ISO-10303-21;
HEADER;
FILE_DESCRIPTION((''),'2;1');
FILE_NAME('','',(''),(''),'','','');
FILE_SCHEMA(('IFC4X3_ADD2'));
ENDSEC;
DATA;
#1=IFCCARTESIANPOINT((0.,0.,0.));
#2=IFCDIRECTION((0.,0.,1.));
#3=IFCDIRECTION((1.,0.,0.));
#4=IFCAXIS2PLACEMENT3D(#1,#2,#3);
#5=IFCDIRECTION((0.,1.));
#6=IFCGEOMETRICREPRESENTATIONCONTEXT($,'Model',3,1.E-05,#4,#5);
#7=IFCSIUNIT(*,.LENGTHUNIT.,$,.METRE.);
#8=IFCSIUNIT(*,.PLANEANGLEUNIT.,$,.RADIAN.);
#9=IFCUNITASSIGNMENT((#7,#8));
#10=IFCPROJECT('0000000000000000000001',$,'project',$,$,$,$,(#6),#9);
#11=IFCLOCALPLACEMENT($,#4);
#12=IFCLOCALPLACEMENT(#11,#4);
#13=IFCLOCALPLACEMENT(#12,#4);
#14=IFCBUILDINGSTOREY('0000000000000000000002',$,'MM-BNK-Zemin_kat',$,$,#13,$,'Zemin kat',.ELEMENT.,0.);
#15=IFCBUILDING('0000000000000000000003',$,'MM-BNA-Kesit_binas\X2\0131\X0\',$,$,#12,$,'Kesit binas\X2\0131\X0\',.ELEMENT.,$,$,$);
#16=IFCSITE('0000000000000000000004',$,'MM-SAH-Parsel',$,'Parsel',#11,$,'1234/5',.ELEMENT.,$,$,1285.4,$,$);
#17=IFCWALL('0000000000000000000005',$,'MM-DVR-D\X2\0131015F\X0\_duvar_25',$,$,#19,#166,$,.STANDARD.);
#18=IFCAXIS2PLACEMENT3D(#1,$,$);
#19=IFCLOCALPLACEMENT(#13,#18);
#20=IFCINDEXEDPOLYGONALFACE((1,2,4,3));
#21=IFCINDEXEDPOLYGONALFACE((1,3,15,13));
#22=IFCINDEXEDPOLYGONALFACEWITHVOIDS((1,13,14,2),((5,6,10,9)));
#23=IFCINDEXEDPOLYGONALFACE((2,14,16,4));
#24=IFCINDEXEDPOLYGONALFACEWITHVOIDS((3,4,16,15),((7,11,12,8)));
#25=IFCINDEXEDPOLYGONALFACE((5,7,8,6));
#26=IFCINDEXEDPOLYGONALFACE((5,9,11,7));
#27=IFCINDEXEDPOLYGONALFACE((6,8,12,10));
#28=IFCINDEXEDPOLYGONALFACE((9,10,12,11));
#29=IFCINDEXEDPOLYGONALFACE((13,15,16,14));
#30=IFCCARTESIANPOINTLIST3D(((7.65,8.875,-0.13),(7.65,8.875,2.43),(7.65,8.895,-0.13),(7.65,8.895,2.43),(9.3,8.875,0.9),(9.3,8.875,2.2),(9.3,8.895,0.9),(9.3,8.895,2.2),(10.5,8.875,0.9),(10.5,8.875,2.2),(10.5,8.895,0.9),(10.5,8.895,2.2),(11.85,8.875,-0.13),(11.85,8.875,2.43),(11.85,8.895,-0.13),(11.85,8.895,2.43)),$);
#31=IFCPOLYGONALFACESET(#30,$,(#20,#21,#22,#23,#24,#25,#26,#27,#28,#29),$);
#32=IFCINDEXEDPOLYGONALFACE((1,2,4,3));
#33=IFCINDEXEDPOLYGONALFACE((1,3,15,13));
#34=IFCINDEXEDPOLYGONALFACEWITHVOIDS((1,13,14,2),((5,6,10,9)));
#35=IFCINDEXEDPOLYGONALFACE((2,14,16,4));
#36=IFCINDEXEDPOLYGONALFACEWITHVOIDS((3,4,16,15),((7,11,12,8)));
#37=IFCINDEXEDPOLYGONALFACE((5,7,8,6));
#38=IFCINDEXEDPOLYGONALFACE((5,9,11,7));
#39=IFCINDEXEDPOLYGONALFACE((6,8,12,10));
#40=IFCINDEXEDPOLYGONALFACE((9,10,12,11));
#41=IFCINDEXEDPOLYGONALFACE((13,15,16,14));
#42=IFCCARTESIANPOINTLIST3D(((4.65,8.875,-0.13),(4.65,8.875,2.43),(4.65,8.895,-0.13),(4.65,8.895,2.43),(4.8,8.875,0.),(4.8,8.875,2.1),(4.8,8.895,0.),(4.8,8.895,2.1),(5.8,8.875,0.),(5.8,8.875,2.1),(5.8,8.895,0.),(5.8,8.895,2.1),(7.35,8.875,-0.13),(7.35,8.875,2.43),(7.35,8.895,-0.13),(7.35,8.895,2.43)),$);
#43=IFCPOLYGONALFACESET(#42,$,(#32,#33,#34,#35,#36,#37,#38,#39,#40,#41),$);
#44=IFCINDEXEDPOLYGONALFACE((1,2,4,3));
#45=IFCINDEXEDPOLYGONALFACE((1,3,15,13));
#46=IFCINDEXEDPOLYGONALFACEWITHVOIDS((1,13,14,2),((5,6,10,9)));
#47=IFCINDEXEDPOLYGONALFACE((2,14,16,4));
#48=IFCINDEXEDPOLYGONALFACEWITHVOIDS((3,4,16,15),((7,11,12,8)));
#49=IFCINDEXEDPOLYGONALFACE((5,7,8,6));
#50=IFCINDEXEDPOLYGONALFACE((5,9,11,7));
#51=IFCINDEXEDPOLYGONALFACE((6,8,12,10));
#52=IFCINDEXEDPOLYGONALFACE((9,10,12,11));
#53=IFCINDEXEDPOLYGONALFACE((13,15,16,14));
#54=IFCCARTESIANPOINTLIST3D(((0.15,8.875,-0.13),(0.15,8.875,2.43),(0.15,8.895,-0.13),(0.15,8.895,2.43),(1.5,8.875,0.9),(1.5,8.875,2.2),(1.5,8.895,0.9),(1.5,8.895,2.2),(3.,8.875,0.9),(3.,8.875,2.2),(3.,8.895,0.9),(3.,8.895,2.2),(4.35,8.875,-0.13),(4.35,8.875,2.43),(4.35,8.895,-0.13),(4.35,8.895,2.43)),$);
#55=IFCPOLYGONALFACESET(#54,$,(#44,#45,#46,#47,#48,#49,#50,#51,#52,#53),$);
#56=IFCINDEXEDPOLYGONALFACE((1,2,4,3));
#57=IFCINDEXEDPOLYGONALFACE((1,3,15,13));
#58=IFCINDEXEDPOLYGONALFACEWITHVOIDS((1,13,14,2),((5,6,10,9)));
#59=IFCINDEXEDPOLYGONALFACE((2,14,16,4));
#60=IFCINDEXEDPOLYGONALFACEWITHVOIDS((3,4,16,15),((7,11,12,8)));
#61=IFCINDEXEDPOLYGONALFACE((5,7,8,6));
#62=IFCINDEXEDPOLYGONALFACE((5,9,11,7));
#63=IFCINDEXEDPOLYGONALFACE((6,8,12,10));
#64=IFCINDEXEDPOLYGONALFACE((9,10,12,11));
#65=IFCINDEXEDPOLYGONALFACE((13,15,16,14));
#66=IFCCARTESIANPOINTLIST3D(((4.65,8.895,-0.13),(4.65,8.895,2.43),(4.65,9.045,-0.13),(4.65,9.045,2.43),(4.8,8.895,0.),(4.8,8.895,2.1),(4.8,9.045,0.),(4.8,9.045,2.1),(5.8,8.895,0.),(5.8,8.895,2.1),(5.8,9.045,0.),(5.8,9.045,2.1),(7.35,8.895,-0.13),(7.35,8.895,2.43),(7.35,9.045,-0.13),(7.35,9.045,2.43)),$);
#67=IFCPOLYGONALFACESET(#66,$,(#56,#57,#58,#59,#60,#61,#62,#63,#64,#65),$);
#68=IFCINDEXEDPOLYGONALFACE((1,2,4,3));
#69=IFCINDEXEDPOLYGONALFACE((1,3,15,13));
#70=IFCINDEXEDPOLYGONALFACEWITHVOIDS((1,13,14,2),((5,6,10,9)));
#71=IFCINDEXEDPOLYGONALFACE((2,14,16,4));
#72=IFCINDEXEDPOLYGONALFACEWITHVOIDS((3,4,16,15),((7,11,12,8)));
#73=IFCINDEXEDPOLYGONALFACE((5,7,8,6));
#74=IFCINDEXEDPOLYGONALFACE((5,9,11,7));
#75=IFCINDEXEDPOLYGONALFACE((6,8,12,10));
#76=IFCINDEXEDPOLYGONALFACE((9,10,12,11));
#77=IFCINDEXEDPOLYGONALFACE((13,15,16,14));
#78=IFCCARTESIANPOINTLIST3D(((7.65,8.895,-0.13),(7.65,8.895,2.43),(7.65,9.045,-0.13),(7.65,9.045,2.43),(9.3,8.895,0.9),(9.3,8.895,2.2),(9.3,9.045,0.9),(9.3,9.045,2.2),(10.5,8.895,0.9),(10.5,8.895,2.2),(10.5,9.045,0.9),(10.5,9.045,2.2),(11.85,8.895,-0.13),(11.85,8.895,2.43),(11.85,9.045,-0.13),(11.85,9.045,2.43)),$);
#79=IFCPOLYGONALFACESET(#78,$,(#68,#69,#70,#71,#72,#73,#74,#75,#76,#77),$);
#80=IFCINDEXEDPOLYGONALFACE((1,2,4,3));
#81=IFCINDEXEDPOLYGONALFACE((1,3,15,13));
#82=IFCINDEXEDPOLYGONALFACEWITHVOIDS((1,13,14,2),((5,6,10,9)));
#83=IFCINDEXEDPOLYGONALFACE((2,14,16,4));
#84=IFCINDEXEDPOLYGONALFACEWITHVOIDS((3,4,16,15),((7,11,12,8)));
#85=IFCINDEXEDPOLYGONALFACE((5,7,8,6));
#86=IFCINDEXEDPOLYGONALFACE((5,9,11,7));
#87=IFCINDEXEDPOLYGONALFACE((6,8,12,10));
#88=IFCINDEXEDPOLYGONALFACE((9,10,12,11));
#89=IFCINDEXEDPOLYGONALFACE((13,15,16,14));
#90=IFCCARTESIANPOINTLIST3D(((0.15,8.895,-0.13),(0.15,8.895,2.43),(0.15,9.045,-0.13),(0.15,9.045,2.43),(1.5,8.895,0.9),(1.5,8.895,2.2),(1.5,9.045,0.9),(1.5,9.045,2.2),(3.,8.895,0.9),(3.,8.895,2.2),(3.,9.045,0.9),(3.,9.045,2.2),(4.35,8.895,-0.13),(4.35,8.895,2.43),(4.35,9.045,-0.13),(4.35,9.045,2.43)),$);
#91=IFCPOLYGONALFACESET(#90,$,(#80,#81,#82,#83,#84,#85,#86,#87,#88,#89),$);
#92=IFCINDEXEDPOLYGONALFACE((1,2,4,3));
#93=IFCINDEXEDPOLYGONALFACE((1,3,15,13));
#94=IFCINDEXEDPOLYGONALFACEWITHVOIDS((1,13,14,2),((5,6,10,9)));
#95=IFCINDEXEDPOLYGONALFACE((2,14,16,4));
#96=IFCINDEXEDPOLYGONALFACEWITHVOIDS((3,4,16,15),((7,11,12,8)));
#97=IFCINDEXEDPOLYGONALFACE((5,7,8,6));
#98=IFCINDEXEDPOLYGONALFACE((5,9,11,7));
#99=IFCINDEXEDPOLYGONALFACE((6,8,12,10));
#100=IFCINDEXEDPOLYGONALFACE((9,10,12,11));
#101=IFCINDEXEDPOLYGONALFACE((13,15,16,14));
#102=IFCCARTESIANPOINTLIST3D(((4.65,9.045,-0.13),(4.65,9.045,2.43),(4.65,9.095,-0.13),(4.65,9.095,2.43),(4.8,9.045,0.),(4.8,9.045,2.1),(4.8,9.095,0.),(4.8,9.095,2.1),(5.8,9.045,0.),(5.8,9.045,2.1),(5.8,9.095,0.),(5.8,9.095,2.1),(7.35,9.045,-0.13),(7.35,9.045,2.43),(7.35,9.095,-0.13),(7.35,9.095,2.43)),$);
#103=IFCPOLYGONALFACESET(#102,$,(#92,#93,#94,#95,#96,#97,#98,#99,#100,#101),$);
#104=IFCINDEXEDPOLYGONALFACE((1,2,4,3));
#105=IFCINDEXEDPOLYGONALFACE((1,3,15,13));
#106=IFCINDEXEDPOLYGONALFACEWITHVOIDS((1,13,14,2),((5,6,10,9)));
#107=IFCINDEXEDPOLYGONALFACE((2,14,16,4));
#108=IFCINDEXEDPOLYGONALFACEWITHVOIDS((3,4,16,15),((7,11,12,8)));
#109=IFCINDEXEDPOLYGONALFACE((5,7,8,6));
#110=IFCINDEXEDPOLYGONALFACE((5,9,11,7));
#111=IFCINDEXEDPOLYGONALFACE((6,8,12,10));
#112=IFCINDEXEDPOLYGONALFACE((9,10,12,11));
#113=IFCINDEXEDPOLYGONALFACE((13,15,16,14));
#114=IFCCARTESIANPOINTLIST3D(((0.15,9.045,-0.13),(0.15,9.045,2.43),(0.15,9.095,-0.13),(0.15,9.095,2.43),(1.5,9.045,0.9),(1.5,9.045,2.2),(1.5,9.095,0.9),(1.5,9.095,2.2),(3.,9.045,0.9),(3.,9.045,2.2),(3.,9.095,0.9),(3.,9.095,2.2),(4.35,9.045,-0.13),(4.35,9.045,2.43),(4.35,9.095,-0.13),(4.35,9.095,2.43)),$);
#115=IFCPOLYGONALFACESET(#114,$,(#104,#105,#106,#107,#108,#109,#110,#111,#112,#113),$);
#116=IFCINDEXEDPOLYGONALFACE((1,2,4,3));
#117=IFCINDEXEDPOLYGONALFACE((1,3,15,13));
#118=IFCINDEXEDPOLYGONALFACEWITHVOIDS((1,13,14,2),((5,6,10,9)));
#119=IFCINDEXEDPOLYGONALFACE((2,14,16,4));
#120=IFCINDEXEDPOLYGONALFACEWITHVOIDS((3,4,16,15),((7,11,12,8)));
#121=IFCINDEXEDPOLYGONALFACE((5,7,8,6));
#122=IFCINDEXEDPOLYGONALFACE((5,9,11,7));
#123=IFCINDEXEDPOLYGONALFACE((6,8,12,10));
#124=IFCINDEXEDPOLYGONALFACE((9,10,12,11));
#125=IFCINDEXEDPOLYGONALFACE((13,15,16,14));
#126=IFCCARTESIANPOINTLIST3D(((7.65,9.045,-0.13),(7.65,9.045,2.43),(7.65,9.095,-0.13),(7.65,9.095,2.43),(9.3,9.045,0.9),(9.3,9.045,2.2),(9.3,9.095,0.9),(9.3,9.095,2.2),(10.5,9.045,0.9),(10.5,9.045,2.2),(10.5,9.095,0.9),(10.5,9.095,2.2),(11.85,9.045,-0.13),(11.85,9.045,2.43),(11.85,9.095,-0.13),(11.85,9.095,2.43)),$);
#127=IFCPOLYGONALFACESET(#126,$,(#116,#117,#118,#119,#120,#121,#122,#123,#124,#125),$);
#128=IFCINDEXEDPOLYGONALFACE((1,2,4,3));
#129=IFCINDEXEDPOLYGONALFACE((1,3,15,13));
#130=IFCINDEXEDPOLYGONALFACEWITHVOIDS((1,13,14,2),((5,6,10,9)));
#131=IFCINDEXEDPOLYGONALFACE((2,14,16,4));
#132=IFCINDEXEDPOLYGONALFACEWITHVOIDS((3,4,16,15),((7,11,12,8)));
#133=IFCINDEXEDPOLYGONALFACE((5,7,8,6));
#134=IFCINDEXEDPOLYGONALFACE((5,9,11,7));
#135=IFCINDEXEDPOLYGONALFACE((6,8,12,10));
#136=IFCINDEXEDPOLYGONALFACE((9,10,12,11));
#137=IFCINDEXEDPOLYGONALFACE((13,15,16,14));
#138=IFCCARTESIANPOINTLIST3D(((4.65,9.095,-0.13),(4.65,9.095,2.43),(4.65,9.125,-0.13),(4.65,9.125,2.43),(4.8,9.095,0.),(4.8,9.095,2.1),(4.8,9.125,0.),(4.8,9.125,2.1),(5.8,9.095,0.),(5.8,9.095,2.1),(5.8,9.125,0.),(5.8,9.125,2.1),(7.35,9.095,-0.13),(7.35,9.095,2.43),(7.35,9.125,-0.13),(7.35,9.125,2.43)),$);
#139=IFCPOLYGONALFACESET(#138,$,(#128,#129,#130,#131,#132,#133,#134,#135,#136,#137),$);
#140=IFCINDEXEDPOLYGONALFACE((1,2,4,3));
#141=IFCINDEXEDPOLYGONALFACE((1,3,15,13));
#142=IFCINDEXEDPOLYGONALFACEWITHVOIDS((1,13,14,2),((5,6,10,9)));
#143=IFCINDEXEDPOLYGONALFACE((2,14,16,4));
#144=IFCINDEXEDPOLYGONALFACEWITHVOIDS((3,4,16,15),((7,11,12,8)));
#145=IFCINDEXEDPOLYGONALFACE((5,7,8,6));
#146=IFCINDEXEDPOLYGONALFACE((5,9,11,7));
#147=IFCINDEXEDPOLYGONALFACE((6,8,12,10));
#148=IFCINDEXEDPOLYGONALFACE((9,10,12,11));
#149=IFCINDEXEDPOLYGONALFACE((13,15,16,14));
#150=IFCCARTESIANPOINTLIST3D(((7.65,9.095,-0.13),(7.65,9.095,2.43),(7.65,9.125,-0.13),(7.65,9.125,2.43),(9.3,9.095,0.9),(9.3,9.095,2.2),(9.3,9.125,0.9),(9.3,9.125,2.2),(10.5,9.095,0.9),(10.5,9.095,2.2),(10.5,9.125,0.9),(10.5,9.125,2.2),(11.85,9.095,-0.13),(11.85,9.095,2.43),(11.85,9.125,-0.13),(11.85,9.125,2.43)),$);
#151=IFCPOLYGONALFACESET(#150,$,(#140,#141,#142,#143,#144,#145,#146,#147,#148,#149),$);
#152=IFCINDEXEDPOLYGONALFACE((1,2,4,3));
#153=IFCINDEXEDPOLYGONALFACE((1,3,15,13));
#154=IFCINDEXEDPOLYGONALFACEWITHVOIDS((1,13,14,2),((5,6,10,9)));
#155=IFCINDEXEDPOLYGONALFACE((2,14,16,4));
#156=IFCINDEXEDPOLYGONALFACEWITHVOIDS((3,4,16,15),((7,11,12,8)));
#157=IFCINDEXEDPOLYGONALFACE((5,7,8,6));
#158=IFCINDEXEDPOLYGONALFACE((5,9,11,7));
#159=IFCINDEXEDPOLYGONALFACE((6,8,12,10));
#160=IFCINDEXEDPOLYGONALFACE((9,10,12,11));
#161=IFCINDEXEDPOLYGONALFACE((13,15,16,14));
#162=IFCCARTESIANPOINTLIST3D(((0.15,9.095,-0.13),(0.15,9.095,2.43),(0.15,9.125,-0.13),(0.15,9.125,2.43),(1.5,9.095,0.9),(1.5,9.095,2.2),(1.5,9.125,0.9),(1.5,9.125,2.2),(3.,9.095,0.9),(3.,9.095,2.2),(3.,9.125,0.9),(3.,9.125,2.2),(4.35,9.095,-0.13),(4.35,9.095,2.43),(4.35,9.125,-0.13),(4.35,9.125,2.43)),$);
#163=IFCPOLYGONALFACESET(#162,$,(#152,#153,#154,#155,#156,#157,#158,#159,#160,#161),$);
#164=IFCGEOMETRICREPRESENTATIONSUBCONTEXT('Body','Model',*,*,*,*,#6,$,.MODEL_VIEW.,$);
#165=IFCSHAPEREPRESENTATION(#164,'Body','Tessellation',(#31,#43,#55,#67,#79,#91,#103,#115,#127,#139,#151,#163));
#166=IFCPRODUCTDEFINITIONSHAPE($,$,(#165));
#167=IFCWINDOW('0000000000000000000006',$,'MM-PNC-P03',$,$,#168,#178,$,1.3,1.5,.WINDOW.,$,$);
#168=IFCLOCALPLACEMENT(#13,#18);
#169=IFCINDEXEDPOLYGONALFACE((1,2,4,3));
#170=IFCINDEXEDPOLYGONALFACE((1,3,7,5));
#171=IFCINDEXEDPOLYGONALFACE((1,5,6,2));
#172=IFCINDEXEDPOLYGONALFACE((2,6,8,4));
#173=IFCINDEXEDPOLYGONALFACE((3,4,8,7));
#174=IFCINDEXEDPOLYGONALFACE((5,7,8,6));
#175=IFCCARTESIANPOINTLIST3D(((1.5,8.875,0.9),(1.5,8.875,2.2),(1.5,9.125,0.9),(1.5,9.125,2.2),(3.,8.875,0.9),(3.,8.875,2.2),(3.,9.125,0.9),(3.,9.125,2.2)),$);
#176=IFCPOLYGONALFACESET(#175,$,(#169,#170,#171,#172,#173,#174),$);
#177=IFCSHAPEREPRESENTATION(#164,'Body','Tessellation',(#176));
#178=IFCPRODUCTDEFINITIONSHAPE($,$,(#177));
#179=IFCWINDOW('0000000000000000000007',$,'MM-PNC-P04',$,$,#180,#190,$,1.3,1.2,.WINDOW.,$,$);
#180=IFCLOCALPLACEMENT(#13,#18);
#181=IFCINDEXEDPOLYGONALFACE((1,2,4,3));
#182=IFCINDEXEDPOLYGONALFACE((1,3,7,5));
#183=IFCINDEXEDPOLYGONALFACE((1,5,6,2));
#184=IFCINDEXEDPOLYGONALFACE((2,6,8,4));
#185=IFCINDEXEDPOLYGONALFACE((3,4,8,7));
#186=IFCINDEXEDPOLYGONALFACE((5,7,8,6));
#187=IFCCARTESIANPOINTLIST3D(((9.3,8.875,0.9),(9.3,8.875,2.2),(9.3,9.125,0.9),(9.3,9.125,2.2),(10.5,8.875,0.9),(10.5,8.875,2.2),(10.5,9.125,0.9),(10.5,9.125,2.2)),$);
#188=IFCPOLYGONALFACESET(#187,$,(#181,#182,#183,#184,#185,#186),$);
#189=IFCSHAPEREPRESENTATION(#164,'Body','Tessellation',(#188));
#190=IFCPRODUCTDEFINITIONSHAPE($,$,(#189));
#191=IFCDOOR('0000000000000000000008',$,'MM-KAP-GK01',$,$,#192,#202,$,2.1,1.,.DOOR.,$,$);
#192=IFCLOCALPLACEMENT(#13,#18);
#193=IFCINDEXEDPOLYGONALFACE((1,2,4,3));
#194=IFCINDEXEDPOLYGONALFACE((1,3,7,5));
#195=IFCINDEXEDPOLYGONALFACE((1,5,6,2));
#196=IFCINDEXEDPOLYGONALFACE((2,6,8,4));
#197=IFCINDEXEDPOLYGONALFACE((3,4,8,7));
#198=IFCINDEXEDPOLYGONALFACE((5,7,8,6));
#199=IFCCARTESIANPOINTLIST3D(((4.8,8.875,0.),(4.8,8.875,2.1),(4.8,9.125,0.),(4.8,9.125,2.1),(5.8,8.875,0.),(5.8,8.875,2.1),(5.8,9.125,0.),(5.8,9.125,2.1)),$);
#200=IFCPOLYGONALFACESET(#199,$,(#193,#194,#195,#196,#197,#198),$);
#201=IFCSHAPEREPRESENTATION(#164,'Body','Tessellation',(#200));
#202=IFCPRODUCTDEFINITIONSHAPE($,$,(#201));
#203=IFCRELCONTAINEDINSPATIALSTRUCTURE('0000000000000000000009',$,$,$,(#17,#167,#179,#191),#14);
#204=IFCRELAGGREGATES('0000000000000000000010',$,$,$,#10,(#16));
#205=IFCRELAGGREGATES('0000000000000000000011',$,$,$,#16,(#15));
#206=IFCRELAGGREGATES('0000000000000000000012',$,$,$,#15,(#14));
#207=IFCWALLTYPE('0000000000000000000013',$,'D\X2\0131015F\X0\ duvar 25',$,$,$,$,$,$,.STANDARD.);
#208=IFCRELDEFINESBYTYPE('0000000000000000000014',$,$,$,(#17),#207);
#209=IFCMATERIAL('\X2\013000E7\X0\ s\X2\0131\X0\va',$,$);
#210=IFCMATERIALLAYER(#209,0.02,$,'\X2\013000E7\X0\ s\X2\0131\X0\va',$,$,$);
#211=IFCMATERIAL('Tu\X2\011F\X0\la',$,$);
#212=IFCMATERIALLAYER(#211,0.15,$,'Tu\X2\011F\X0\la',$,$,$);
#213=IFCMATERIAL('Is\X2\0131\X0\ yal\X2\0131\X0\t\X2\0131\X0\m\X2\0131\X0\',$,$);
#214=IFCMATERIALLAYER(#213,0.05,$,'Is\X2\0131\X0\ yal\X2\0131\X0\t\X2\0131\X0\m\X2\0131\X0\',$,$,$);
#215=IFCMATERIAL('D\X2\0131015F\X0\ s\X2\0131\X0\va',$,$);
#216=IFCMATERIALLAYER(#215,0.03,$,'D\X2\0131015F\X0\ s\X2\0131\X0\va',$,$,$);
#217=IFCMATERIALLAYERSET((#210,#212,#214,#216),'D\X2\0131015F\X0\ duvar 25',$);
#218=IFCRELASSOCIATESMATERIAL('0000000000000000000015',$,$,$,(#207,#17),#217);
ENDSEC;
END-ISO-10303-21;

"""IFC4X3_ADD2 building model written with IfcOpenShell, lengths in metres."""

from ifc_helpers import new_model, si_unit, direction, frame, origin, origin_with_axes, place, context, subcontext, project, spatial, polyline, outline, extrude, material, layer, layer_set, type_object, element, fill, save


model = new_model("IFC4X3_ADD2")

# Units and contexts
model_context = context("Model", 3, precision=1e-05, world=origin_with_axes(), true_north=direction((0.0, 1.0)))
body_context = subcontext(model_context, "Body", "Model", "MODEL_VIEW")
ifc_project = project(units=[si_unit("LENGTHUNIT", "METRE"), si_unit("PLANEANGLEUNIT", "RADIAN")], contexts=[model_context])

# Site, building, storey
site_placement = place(None, origin_with_axes())
site = spatial("IfcSite", under=ifc_project, at=site_placement, Name="MM-SAH-Parsel", ObjectType="Parsel", LongName="1234/5", CompositionType="ELEMENT", RefElevation=1285.4)
building_placement = place(site_placement, origin_with_axes())
building = spatial("IfcBuilding", under=site, at=building_placement, Name="MM-BNA-Kesit_binası", LongName="Kesit binası", CompositionType="ELEMENT")
storey_placement = place(building_placement, origin_with_axes())
storey = spatial("IfcBuildingStorey", under=building, at=storey_placement, Name="MM-BNK-Zemin_kat", LongName="Zemin kat", CompositionType="ELEMENT", Elevation=0.0)

# Shared definitions
ifc_material_1 = material(Name="İç sıva")
ifc_layer_1 = layer(ifc_material_1, 0.02, Name="İç sıva")
ifc_material_2 = material(Name="Tuğla")
ifc_layer_2 = layer(ifc_material_2, 0.15, Name="Tuğla")
ifc_material_3 = material(Name="Isı yalıtımı")
ifc_layer_3 = layer(ifc_material_3, 0.05, Name="Isı yalıtımı")
ifc_material_4 = material(Name="Dış sıva")
ifc_layer_4 = layer(ifc_material_4, 0.03, Name="Dış sıva")
ifc_layer_set_1 = layer_set([ifc_layer_1, ifc_layer_2, ifc_layer_3, ifc_layer_4], Name="Dış duvar 25")
wall_type_1 = type_object("IfcWallType", Name="Dış duvar 25", PredefinedType="STANDARD", material=ifc_layer_set_1)

# Wall, openings, windows, door
wall_1_placement = place(storey_placement, origin_with_axes())
wall_1 = element("IfcWall", 1, at=wall_1_placement, inside=storey, type_object=wall_type_1, material=ifc_layer_set_1, Name="MM-DVR-Dış_duvar_25", PredefinedType="STANDARD", context=body_context, shape_type="SweptSolid", body=[
    extrude(outline(polyline([(11.85, 8.895), (7.65, 8.895), (7.65, 8.875), (11.85, 8.875), (11.85, 8.895)])), frame((0.0, 0.0, -0.13)), (0.0, 0.0, 1.0), 2.56),
    extrude(outline(polyline([(7.35, 8.895), (4.65, 8.895), (4.65, 8.875), (7.35, 8.875), (7.35, 8.895)])), frame((0.0, 0.0, -0.13)), (0.0, 0.0, 1.0), 2.56),
    extrude(outline(polyline([(4.35, 8.895), (0.15, 8.895), (0.15, 8.875), (4.35, 8.875), (4.35, 8.895)])), frame((0.0, 0.0, -0.13)), (0.0, 0.0, 1.0), 2.56),
    extrude(outline(polyline([(7.35, 9.045), (4.65, 9.045), (4.65, 8.895), (7.35, 8.895), (7.35, 9.045)])), frame((0.0, 0.0, -0.13)), (0.0, 0.0, 1.0), 2.56),
    extrude(outline(polyline([(11.85, 9.045), (7.65, 9.045), (7.65, 8.895), (11.85, 8.895), (11.85, 9.045)])), frame((0.0, 0.0, -0.13)), (0.0, 0.0, 1.0), 2.56),
    extrude(outline(polyline([(4.35, 9.045), (0.15, 9.045), (0.15, 8.895), (4.35, 8.895), (4.35, 9.045)])), frame((0.0, 0.0, -0.13)), (0.0, 0.0, 1.0), 2.56),
    extrude(outline(polyline([(7.35, 9.095), (4.65, 9.095), (4.65, 9.045), (7.35, 9.045), (7.35, 9.095)])), frame((0.0, 0.0, -0.13)), (0.0, 0.0, 1.0), 2.56),
    extrude(outline(polyline([(4.35, 9.095), (0.15, 9.095), (0.15, 9.045), (4.35, 9.045), (4.35, 9.095)])), frame((0.0, 0.0, -0.13)), (0.0, 0.0, 1.0), 2.56),
    extrude(outline(polyline([(11.85, 9.095), (7.65, 9.095), (7.65, 9.045), (11.85, 9.045), (11.85, 9.095)])), frame((0.0, 0.0, -0.13)), (0.0, 0.0, 1.0), 2.56),
    extrude(outline(polyline([(7.35, 9.125), (4.65, 9.125), (4.65, 9.095), (7.35, 9.095), (7.35, 9.125)])), frame((0.0, 0.0, -0.13)), (0.0, 0.0, 1.0), 2.56),
    extrude(outline(polyline([(11.85, 9.125), (7.65, 9.125), (7.65, 9.095), (11.85, 9.095), (11.85, 9.125)])), frame((0.0, 0.0, -0.13)), (0.0, 0.0, 1.0), 2.56),
    extrude(outline(polyline([(4.35, 9.125), (0.15, 9.125), (0.15, 9.095), (4.35, 9.095), (4.35, 9.125)])), frame((0.0, 0.0, -0.13)), (0.0, 0.0, 1.0), 2.56),
])
opening_1_placement = place(storey_placement, origin_with_axes())
opening_1 = element("IfcOpeningElement", 2, at=opening_1_placement, cuts=wall_1, PredefinedType="OPENING", context=body_context, shape_type="SweptSolid", body=[
    extrude(outline(polyline([(3.0, 8.875), (1.5, 8.875), (1.5, 9.125), (3.0, 9.125), (3.0, 8.875)])), frame((0.0, 0.0, 0.9)), (0.0, 0.0, 1.0), 1.3),
])
opening_2_placement = place(storey_placement, origin_with_axes())
opening_2 = element("IfcOpeningElement", 3, at=opening_2_placement, cuts=wall_1, PredefinedType="OPENING", context=body_context, shape_type="SweptSolid", body=[
    extrude(outline(polyline([(10.5, 8.875), (9.3, 8.875), (9.3, 9.125), (10.5, 9.125), (10.5, 8.875)])), frame((0.0, 0.0, 0.9)), (0.0, 0.0, 1.0), 1.3),
])
opening_3_placement = place(storey_placement, origin_with_axes())
opening_3 = element("IfcOpeningElement", 4, at=opening_3_placement, cuts=wall_1, PredefinedType="OPENING", context=body_context, shape_type="SweptSolid", body=[
    extrude(outline(polyline([(5.8, 8.875), (4.8, 8.875), (4.8, 9.125), (5.8, 9.125), (5.8, 8.875)])), origin(), (0.0, 0.0, 1.0), 2.1),
])
window_1_placement = place(storey_placement, origin_with_axes())
window_1 = element("IfcWindow", 5, at=window_1_placement, inside=storey, Name="MM-PNC-P03", OverallHeight=1.3, OverallWidth=1.5, PredefinedType="WINDOW", context=body_context, shape_type="SweptSolid", body=[
    extrude(outline(polyline([(3.0, 8.875), (1.5, 8.875), (1.5, 9.125), (3.0, 9.125), (3.0, 8.875)])), frame((0.0, 0.0, 0.9)), (0.0, 0.0, 1.0), 1.3),
])
fill(opening_1, window_1)
window_2_placement = place(storey_placement, origin_with_axes())
window_2 = element("IfcWindow", 6, at=window_2_placement, inside=storey, Name="MM-PNC-P04", OverallHeight=1.3, OverallWidth=1.2, PredefinedType="WINDOW", context=body_context, shape_type="SweptSolid", body=[
    extrude(outline(polyline([(10.5, 8.875), (9.3, 8.875), (9.3, 9.125), (10.5, 9.125), (10.5, 8.875)])), frame((0.0, 0.0, 0.9)), (0.0, 0.0, 1.0), 1.3),
])
fill(opening_2, window_2)
door_1_placement = place(storey_placement, origin_with_axes())
door_1 = element("IfcDoor", 7, at=door_1_placement, inside=storey, Name="MM-KAP-GK01", OverallHeight=2.1, OverallWidth=1.0, PredefinedType="DOOR", context=body_context, shape_type="SweptSolid", body=[
    extrude(outline(polyline([(5.8, 8.875), (4.8, 8.875), (4.8, 9.125), (5.8, 9.125), (5.8, 8.875)])), origin(), (0.0, 0.0, 1.0), 2.1),
])
fill(opening_3, door_1)

save(model, "model.ifc")
